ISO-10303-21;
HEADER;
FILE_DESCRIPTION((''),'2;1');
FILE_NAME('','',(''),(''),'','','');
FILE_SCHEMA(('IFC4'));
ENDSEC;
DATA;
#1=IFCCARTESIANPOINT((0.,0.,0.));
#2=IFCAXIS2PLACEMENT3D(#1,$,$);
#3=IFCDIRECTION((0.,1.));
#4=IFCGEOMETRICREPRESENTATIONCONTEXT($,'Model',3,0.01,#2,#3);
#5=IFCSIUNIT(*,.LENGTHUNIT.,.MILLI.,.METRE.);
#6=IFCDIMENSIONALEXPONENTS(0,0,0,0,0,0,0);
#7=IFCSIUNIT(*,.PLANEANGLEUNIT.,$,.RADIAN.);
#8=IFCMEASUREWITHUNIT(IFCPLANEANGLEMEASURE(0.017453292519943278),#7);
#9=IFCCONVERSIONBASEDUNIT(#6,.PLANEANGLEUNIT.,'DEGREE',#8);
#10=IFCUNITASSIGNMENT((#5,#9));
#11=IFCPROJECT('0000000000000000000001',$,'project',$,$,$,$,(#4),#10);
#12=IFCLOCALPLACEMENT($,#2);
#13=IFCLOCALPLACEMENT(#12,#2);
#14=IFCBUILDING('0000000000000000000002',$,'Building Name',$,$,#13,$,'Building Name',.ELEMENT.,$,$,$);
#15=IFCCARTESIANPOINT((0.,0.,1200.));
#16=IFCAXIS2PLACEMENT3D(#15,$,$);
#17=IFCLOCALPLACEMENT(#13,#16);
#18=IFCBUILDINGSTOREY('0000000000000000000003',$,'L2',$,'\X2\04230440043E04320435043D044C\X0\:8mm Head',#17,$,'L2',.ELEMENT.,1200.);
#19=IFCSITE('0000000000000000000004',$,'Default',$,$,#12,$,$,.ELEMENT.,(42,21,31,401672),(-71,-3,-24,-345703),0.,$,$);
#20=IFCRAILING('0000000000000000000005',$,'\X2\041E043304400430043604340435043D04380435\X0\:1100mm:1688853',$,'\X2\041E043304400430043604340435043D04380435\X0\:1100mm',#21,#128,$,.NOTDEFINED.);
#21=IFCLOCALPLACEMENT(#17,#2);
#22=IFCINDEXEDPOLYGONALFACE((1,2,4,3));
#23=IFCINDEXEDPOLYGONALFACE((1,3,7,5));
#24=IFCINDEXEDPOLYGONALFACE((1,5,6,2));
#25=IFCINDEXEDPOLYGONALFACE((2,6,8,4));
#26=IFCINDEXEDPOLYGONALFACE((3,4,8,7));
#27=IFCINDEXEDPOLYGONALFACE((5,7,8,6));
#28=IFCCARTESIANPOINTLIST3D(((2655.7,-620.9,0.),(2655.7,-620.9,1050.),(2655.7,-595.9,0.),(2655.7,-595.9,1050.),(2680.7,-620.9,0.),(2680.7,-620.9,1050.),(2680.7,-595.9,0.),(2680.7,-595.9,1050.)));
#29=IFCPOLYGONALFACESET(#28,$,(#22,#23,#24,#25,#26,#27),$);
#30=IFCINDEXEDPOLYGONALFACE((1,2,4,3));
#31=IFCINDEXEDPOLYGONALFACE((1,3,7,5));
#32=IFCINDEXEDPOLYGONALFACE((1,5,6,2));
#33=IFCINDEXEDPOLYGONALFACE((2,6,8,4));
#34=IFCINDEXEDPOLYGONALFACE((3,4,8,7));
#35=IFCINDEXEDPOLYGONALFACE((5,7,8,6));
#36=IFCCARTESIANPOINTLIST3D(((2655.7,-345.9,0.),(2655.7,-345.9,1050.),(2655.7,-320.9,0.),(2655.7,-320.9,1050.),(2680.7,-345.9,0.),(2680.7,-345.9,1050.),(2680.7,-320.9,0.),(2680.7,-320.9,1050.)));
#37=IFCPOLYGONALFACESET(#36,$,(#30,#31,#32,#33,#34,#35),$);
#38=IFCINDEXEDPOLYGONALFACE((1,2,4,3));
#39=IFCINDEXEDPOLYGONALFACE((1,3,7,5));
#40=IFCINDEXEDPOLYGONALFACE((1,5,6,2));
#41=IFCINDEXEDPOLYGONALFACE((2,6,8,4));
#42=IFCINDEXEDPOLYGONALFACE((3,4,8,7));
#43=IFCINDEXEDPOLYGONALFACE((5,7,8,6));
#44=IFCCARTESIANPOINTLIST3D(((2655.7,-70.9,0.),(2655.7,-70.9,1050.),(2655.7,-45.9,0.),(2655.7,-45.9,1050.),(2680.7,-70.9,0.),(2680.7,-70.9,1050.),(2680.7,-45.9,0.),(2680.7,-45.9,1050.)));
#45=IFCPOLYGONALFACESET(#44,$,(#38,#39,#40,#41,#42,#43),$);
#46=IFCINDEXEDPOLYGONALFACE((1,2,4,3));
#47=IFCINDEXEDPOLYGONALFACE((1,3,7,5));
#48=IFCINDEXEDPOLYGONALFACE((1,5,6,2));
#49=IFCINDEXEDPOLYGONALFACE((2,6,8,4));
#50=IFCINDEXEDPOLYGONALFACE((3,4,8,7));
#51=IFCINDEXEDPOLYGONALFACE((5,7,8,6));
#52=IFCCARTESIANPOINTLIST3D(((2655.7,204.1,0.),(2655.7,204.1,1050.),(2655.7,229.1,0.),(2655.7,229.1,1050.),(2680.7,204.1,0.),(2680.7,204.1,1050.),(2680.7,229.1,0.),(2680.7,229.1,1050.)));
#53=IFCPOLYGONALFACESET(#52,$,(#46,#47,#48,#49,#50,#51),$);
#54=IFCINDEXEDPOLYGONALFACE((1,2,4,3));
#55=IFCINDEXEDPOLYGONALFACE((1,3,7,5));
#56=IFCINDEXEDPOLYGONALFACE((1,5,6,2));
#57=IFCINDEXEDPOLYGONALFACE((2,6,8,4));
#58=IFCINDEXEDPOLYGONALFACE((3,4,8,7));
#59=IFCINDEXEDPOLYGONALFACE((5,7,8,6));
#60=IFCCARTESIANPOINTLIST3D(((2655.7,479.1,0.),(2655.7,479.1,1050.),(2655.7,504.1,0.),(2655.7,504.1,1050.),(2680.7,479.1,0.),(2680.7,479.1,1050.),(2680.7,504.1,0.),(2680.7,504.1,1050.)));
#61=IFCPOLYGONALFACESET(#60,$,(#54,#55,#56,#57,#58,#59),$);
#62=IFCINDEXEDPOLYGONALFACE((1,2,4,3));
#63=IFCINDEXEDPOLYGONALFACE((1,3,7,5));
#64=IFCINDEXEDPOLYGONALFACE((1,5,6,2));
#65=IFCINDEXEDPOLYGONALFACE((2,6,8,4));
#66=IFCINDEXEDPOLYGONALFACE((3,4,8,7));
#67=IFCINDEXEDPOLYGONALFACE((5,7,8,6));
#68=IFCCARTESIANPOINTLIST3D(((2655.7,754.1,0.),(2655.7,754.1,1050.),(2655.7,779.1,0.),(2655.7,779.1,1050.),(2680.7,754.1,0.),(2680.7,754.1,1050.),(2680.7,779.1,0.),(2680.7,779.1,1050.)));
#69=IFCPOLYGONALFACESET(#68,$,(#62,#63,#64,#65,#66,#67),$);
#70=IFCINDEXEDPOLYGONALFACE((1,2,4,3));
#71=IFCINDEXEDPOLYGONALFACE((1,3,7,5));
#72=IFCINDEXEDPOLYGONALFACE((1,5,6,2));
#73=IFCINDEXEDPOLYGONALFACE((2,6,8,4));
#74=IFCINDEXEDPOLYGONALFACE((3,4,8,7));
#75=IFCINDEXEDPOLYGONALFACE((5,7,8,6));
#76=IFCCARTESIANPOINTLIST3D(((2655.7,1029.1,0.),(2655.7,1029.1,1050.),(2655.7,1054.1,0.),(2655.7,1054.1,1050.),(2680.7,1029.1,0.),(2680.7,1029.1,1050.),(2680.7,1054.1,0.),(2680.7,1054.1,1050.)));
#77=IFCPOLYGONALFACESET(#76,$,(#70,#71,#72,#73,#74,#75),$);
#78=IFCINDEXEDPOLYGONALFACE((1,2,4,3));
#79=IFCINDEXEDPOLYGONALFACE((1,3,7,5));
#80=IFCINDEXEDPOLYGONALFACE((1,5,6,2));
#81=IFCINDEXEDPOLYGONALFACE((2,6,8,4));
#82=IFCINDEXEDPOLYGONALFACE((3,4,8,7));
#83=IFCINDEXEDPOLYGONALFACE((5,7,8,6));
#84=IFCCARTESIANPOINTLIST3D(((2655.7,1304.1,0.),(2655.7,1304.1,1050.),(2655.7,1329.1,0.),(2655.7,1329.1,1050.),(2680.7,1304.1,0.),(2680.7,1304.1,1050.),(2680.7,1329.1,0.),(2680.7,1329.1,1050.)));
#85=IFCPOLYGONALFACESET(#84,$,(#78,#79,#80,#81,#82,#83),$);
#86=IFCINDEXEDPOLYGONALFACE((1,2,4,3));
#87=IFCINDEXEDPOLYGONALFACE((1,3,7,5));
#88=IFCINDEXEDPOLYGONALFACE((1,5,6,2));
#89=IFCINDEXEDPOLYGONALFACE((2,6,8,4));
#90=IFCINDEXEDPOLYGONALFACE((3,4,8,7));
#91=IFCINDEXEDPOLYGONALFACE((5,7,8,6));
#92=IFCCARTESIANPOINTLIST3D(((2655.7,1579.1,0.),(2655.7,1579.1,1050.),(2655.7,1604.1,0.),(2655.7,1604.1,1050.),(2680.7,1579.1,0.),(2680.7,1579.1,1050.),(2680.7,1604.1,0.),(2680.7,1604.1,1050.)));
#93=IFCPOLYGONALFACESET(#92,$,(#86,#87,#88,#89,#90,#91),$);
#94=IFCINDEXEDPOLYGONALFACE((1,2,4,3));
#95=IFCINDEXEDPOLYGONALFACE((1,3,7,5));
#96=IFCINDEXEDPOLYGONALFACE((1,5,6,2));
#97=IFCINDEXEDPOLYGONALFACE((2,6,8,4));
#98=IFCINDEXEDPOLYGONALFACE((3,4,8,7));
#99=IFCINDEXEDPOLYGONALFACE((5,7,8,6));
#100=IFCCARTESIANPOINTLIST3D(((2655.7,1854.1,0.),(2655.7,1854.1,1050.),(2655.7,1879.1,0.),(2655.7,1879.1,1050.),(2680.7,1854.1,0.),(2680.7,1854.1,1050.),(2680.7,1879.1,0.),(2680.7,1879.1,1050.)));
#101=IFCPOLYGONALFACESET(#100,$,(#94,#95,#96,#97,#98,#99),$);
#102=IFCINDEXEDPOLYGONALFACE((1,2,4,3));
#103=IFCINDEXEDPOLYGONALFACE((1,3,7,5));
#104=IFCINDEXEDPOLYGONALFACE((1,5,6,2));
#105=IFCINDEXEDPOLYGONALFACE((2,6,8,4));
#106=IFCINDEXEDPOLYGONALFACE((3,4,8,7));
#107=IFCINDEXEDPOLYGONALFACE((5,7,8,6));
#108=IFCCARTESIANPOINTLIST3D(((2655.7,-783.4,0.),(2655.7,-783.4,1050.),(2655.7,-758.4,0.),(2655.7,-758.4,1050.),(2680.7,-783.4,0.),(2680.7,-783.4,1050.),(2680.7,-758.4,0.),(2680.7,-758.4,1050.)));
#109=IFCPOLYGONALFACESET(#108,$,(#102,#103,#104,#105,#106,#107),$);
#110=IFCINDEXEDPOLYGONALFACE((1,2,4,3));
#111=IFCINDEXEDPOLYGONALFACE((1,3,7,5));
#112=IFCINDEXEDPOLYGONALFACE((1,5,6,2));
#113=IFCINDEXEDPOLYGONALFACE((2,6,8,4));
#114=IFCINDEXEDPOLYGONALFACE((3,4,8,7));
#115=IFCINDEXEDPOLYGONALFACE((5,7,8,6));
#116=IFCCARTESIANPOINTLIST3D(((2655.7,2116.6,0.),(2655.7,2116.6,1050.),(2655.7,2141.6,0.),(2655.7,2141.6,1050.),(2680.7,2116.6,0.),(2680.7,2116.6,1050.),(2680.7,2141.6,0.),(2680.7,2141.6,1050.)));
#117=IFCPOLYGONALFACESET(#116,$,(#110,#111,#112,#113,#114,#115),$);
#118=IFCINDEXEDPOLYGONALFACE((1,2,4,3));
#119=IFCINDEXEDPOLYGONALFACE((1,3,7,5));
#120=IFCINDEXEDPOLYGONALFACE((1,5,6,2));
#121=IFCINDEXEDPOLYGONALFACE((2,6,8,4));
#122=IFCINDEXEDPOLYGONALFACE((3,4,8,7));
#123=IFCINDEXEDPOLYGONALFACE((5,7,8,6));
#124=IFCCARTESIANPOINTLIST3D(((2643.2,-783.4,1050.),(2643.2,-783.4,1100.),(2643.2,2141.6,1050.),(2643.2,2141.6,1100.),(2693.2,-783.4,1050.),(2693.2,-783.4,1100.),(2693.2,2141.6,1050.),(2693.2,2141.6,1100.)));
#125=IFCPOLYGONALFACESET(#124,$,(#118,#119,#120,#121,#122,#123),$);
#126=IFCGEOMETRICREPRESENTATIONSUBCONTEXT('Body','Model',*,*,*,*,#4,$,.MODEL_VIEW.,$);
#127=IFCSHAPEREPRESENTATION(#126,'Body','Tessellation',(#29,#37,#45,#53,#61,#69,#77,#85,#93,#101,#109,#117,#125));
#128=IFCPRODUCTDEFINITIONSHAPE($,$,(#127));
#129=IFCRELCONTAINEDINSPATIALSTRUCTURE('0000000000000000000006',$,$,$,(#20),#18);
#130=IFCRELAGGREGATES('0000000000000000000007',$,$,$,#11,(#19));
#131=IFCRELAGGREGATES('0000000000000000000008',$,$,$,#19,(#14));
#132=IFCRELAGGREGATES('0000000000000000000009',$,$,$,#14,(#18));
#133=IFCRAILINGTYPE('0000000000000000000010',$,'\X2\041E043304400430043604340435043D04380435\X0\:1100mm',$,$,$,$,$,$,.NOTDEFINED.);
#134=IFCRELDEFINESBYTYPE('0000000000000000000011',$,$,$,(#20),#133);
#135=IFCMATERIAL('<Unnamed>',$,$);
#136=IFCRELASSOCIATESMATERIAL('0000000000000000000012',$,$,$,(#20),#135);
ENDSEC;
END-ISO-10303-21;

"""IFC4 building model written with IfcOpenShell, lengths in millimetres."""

from ifc_helpers import new_model, entity, si_unit, converted_unit, direction, frame, frame_2d, origin, origin_2d_with_axis, place, context, subcontext, project, spatial, rectangle, extrude, material, type_object, element, save


model = new_model("IFC4")

# Units and contexts
model_context = context("Model", 3, precision=0.01, world=origin(), true_north=direction((0.0, 1.0)))
body_context = subcontext(model_context, "Body", "Model", "MODEL_VIEW")
ifc_project = project(units=[si_unit("LENGTHUNIT", "METRE", prefix="MILLI"), converted_unit("PLANEANGLEUNIT", "DEGREE", entity("IfcPlaneAngleMeasure", 0.017453292519943278), si_unit("PLANEANGLEUNIT", "RADIAN"), dimensions=[0, 0, 0, 0, 0, 0, 0])], contexts=[model_context])

# Site, building, storey
site_placement = place(None, origin())
site = spatial("IfcSite", under=ifc_project, at=site_placement, Name="Default", CompositionType="ELEMENT", RefLatitude=(42, 21, 31, 401672), RefLongitude=(-71, -3, -24, -345703), RefElevation=0.0)
building_placement = place(site_placement, origin())
building = spatial("IfcBuilding", under=site, at=building_placement, Name="Building Name", LongName="Building Name", CompositionType="ELEMENT")
storey_placement = place(building_placement, frame((0.0, 0.0, 1200.0)))
storey = spatial("IfcBuildingStorey", under=building, at=storey_placement, Name="L2", ObjectType="Уровень:8mm Head", LongName="L2", CompositionType="ELEMENT", Elevation=1200.0)

# Railing
ifc_material_1 = material(Name="<Unnamed>")
railing_type = type_object("IfcRailingType", Name="Ограждение:1100mm", PredefinedType="NOTDEFINED")
railing_1_placement = place(storey_placement, frame((2643.2, -783.4, 0.0)))
element("IfcRailing", 1, at=railing_1_placement, inside=storey, type_object=railing_type, material=ifc_material_1, Name="Ограждение:1100mm:1688853", ObjectType="Ограждение:1100mm", PredefinedType="NOTDEFINED", context=body_context, shape_type="SweptSolid", body=[
    extrude(rectangle(XDim=25.0, YDim=25.0, at=frame_2d((0.0, 0.0), x_axis=(1.0, 0.0))), frame((25.0, 175.0, 0.0), z_axis=(0.0, 0.0, 1.0), x_axis=(0.0, -1.0, 0.0)), (0.0, 0.0, 1.0), 1050.0),
    extrude(rectangle(XDim=25.0, YDim=25.0, at=origin_2d_with_axis()), frame((25.0, 450.0, 0.0), z_axis=(0.0, 0.0, 1.0), x_axis=(0.0, -1.0, 0.0)), (0.0, 0.0, 1.0), 1050.0),
    extrude(rectangle(XDim=25.0, YDim=25.0, at=origin_2d_with_axis()), frame((25.0, 725.0, 0.0), z_axis=(0.0, 0.0, 1.0), x_axis=(0.0, -1.0, 0.0)), (0.0, 0.0, 1.0), 1050.0),
    extrude(rectangle(XDim=25.0, YDim=25.0, at=origin_2d_with_axis()), frame((25.0, 1000.0, 0.0), z_axis=(0.0, 0.0, 1.0), x_axis=(0.0, -1.0, 0.0)), (0.0, 0.0, 1.0), 1050.0),
    extrude(rectangle(XDim=25.0, YDim=25.0, at=origin_2d_with_axis()), frame((25.0, 1275.0, 0.0), z_axis=(0.0, 0.0, 1.0), x_axis=(0.0, -1.0, 0.0)), (0.0, 0.0, 1.0), 1050.0),
    extrude(rectangle(XDim=25.0, YDim=25.0, at=origin_2d_with_axis()), frame((25.0, 1550.0, 0.0), z_axis=(0.0, 0.0, 1.0), x_axis=(0.0, -1.0, 0.0)), (0.0, 0.0, 1.0), 1050.0),
    extrude(rectangle(XDim=25.0, YDim=25.0, at=origin_2d_with_axis()), frame((25.0, 1825.0, 0.0), z_axis=(0.0, 0.0, 1.0), x_axis=(0.0, -1.0, 0.0)), (0.0, 0.0, 1.0), 1050.0),
    extrude(rectangle(XDim=25.0, YDim=25.0, at=origin_2d_with_axis()), frame((25.0, 2100.0, 0.0), z_axis=(0.0, 0.0, 1.0), x_axis=(0.0, -1.0, 0.0)), (0.0, 0.0, 1.0), 1050.0),
    extrude(rectangle(XDim=25.0, YDim=25.0, at=origin_2d_with_axis()), frame((25.0, 2375.0, 0.0), z_axis=(0.0, 0.0, 1.0), x_axis=(0.0, -1.0, 0.0)), (0.0, 0.0, 1.0), 1050.0),
    extrude(rectangle(XDim=25.0, YDim=25.0, at=origin_2d_with_axis()), frame((25.0, 2650.0, 0.0), z_axis=(0.0, 0.0, 1.0), x_axis=(0.0, -1.0, 0.0)), (0.0, 0.0, 1.0), 1050.0),
    extrude(rectangle(XDim=25.0, YDim=25.0, at=origin_2d_with_axis()), frame((25.0, 12.5, 0.0), z_axis=(0.0, 0.0, 1.0), x_axis=(0.0, -1.0, 0.0)), (0.0, 0.0, 1.0), 1050.0),
    extrude(rectangle(XDim=25.0, YDim=25.0, at=origin_2d_with_axis()), frame((25.0, 2912.5, 0.0), z_axis=(0.0, 0.0, 1.0), x_axis=(0.0, -1.0, 0.0)), (0.0, 0.0, 1.0), 1050.0),
    extrude(rectangle(XDim=2925.0, YDim=50.0, at=frame_2d((0.0, 0.0), x_axis=(1.0, 0.0))), frame((25.0, 1462.5, 1050.0), z_axis=(0.0, 0.0, 1.0), x_axis=(0.0, -1.0, 0.0)), (0.0, 0.0, 1.0), 50.0),
])

save(model, "model.ifc")
